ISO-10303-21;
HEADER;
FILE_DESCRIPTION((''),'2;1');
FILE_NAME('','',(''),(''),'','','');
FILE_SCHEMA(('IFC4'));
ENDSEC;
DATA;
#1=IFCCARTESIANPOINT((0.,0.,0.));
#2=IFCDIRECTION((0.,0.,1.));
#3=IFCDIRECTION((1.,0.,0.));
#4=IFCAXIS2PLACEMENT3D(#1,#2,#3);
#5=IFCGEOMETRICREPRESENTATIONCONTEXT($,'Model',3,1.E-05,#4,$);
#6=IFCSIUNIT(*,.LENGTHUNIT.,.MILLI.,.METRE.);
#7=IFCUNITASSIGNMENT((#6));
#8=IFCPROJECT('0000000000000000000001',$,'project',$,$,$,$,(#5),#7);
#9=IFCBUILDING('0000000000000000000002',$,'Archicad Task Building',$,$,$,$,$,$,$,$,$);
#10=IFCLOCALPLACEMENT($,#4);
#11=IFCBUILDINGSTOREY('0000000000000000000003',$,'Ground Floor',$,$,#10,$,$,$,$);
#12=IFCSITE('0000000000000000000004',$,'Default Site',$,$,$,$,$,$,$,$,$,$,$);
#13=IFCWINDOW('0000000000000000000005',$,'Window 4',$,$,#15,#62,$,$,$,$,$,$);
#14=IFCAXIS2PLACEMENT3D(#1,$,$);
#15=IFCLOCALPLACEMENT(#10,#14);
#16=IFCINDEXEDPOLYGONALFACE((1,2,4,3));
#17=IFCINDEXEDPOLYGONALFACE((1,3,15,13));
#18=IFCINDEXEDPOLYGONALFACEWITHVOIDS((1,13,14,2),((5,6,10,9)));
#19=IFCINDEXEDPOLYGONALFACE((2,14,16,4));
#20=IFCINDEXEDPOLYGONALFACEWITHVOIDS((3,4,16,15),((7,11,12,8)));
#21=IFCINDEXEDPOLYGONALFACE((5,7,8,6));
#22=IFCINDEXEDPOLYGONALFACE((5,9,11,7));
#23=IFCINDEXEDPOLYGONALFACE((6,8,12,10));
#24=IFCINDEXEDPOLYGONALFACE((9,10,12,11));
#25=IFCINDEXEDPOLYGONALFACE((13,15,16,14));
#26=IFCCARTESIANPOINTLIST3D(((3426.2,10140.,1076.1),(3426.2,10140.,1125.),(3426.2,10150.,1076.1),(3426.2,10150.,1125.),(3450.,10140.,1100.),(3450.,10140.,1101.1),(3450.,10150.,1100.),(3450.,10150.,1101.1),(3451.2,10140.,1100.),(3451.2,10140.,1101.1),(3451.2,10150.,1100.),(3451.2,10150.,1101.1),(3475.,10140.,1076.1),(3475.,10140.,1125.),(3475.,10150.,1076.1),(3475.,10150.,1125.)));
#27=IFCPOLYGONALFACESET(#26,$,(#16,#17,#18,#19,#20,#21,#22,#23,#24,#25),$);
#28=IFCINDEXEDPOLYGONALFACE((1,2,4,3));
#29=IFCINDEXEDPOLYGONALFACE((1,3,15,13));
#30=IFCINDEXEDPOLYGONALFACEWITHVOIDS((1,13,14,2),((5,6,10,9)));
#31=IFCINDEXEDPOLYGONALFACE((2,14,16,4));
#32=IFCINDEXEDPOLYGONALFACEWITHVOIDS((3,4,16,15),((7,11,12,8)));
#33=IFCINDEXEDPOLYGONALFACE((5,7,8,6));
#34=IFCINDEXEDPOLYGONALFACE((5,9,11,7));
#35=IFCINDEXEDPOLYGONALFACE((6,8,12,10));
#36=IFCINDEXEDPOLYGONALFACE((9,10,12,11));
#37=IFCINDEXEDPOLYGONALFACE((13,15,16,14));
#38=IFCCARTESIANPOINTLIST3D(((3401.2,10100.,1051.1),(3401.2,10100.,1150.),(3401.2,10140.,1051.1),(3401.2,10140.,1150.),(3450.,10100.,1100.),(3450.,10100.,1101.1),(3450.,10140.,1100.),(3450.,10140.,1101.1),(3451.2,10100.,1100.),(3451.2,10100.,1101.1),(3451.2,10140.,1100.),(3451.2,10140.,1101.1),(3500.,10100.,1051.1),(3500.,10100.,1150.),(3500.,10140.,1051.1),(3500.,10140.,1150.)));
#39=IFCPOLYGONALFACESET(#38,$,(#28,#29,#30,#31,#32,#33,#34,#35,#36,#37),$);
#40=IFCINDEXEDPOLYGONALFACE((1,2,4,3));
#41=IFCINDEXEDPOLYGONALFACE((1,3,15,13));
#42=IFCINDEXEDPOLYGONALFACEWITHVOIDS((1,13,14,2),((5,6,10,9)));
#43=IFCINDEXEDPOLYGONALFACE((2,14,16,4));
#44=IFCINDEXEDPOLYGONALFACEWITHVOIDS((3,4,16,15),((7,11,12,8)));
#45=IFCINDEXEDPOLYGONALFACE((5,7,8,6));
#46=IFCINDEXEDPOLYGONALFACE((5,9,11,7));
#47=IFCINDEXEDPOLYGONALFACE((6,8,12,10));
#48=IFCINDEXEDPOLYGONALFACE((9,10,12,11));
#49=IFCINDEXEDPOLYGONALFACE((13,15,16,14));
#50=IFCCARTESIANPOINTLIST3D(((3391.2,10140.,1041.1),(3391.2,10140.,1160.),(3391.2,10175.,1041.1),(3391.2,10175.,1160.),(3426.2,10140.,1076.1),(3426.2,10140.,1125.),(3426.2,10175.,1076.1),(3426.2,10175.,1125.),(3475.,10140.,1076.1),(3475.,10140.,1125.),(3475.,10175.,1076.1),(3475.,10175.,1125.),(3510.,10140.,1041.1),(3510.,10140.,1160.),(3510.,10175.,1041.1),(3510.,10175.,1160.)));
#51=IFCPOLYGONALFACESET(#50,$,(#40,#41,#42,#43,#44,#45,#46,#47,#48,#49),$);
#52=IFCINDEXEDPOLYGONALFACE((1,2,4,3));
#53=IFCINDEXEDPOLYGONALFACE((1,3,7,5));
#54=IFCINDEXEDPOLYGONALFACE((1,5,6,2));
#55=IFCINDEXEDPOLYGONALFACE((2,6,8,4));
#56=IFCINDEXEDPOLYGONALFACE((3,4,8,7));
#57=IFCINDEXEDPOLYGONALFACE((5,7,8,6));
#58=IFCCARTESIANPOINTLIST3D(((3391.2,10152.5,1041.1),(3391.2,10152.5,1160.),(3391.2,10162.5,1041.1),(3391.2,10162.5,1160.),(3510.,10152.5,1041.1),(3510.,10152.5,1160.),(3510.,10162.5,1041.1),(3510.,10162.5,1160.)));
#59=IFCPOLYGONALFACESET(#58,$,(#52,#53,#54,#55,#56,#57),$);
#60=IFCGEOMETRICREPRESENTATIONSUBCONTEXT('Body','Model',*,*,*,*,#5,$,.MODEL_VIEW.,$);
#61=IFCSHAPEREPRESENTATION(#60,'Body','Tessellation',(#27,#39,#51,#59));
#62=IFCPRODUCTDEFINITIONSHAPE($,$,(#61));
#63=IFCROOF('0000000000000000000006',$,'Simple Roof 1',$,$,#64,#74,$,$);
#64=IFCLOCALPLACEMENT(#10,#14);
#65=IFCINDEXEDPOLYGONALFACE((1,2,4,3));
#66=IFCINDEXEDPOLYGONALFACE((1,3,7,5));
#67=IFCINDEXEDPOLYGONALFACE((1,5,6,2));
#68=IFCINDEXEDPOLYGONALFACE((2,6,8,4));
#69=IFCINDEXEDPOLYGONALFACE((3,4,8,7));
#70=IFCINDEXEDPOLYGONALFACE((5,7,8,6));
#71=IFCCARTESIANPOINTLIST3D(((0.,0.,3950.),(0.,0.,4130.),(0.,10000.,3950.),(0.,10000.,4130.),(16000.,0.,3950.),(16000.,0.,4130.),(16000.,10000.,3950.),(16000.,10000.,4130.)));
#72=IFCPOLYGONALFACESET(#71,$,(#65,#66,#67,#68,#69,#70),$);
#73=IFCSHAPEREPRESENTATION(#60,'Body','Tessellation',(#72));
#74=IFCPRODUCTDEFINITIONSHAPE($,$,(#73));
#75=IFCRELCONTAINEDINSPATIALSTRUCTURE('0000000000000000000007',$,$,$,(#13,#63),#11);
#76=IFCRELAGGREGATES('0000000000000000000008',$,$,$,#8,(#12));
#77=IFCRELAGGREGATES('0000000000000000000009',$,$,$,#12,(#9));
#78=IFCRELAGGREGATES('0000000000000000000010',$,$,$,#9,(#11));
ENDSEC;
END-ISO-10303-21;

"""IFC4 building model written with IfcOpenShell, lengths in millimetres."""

from ifc_helpers import new_model, si_unit, frame, origin_with_axes, place, context, subcontext, project, spatial, line, indexed_curve, outline, extrude, element, save


model = new_model("IFC4")

# Units and contexts
model_context = context("Model", 3, precision=1e-05, world=origin_with_axes())
body_context = subcontext(model_context, "Body", "Model", "MODEL_VIEW")
ifc_project = project(units=[si_unit("LENGTHUNIT", "METRE", prefix="MILLI")], contexts=[model_context])

# Site, building, storey
site = spatial("IfcSite", under=ifc_project, Name="Default Site")
building = spatial("IfcBuilding", under=site, Name="Archicad Task Building")
storey_placement = place(None, origin_with_axes())
storey = spatial("IfcBuildingStorey", under=building, at=storey_placement, Name="Ground Floor")

# Window
for number, where, z_axis, x_axis, name in (
    (1, (3450.0, 10050.0, 1100.0), (0.0, 0.0, 1.0), (1.0, 0.0, 0.0), "Window 4"),
):
    element("IfcWindow", number, at=place(storey_placement, frame(where, z_axis=z_axis, x_axis=x_axis)), inside=storey, Name=name, context=body_context, shape_type="SweptSolid", body=[
        extrude(outline(indexed_curve([(0.0, 0.0), (1.2, 0.0), (1.2, 1.1), (0.0, 1.1)], segments=[line(1, 2, 3, 4, 1)]), holes=[indexed_curve([(25.0, 25.0), (-23.8, 25.0), (-23.8, -23.9), (25.0, -23.9)], segments=[line(1, 2, 3, 4, 1)])]), frame((0.0, 90.0, 0.0), z_axis=(0.0, -1.0, 0.0), x_axis=(1.0, 0.0, 0.0)), (0.0, 0.0, -1.0), 10.0),
        extrude(outline(indexed_curve([(0.0, 0.0), (1.2, 0.0), (1.2, 1.1), (0.0, 1.1)], segments=[line(1, 2, 3, 4, 1)]), holes=[indexed_curve([(50.0, 50.0), (-48.8, 50.0), (-48.8, -48.9), (50.0, -48.9)], segments=[line(1, 2, 3, 4, 1)])]), frame((0.0, 50.0, 0.0), z_axis=(0.0, -1.0, 0.0), x_axis=(1.0, 0.0, 0.0)), (0.0, 0.0, -1.0), 40.0),
        extrude(outline(indexed_curve([(0.0, 0.0), (-48.8, 0.0), (-48.8, -48.9), (0.0, -48.9)], segments=[line(1, 2, 3, 4, 1)]), holes=[indexed_curve([(35.0, 35.0), (-83.8, 35.0), (-83.8, -83.9), (35.0, -83.9)], segments=[line(1, 2, 3, 4, 1)])]), frame((25.0, 90.0, 25.0), z_axis=(0.0, -1.0, 0.0), x_axis=(1.0, 0.0, 0.0)), (0.0, 0.0, -1.0), 35.0),
        extrude(outline(indexed_curve([(35.0, 35.0), (-83.8, 35.0), (-83.8, -83.9), (35.0, -83.9)], segments=[line(1, 2, 3, 4, 1)])), frame((25.0, 102.5, 25.0), z_axis=(0.0, -1.0, 0.0), x_axis=(1.0, 0.0, 0.0)), (0.0, 0.0, -1.0), 10.0),
    ])

# Roof
roof_placement = place(storey_placement, frame((0.0, 0.0, 3950.0), z_axis=(0.0, 0.0, 1.0), x_axis=(1.0, 0.0, 0.0)))
element("IfcRoof", 2, at=roof_placement, inside=storey, Name="Simple Roof 1", context=body_context, shape_type="SweptSolid", body=[
    extrude(outline(indexed_curve([(0.0, 0.0), (16000.0, 0.0), (16000.0, 10000.0), (0.0, 10000.0), (0.0, 0.0)])), None, (0.0, 0.0, 1.0), 180.0),
])

save(model, "model.ifc")
